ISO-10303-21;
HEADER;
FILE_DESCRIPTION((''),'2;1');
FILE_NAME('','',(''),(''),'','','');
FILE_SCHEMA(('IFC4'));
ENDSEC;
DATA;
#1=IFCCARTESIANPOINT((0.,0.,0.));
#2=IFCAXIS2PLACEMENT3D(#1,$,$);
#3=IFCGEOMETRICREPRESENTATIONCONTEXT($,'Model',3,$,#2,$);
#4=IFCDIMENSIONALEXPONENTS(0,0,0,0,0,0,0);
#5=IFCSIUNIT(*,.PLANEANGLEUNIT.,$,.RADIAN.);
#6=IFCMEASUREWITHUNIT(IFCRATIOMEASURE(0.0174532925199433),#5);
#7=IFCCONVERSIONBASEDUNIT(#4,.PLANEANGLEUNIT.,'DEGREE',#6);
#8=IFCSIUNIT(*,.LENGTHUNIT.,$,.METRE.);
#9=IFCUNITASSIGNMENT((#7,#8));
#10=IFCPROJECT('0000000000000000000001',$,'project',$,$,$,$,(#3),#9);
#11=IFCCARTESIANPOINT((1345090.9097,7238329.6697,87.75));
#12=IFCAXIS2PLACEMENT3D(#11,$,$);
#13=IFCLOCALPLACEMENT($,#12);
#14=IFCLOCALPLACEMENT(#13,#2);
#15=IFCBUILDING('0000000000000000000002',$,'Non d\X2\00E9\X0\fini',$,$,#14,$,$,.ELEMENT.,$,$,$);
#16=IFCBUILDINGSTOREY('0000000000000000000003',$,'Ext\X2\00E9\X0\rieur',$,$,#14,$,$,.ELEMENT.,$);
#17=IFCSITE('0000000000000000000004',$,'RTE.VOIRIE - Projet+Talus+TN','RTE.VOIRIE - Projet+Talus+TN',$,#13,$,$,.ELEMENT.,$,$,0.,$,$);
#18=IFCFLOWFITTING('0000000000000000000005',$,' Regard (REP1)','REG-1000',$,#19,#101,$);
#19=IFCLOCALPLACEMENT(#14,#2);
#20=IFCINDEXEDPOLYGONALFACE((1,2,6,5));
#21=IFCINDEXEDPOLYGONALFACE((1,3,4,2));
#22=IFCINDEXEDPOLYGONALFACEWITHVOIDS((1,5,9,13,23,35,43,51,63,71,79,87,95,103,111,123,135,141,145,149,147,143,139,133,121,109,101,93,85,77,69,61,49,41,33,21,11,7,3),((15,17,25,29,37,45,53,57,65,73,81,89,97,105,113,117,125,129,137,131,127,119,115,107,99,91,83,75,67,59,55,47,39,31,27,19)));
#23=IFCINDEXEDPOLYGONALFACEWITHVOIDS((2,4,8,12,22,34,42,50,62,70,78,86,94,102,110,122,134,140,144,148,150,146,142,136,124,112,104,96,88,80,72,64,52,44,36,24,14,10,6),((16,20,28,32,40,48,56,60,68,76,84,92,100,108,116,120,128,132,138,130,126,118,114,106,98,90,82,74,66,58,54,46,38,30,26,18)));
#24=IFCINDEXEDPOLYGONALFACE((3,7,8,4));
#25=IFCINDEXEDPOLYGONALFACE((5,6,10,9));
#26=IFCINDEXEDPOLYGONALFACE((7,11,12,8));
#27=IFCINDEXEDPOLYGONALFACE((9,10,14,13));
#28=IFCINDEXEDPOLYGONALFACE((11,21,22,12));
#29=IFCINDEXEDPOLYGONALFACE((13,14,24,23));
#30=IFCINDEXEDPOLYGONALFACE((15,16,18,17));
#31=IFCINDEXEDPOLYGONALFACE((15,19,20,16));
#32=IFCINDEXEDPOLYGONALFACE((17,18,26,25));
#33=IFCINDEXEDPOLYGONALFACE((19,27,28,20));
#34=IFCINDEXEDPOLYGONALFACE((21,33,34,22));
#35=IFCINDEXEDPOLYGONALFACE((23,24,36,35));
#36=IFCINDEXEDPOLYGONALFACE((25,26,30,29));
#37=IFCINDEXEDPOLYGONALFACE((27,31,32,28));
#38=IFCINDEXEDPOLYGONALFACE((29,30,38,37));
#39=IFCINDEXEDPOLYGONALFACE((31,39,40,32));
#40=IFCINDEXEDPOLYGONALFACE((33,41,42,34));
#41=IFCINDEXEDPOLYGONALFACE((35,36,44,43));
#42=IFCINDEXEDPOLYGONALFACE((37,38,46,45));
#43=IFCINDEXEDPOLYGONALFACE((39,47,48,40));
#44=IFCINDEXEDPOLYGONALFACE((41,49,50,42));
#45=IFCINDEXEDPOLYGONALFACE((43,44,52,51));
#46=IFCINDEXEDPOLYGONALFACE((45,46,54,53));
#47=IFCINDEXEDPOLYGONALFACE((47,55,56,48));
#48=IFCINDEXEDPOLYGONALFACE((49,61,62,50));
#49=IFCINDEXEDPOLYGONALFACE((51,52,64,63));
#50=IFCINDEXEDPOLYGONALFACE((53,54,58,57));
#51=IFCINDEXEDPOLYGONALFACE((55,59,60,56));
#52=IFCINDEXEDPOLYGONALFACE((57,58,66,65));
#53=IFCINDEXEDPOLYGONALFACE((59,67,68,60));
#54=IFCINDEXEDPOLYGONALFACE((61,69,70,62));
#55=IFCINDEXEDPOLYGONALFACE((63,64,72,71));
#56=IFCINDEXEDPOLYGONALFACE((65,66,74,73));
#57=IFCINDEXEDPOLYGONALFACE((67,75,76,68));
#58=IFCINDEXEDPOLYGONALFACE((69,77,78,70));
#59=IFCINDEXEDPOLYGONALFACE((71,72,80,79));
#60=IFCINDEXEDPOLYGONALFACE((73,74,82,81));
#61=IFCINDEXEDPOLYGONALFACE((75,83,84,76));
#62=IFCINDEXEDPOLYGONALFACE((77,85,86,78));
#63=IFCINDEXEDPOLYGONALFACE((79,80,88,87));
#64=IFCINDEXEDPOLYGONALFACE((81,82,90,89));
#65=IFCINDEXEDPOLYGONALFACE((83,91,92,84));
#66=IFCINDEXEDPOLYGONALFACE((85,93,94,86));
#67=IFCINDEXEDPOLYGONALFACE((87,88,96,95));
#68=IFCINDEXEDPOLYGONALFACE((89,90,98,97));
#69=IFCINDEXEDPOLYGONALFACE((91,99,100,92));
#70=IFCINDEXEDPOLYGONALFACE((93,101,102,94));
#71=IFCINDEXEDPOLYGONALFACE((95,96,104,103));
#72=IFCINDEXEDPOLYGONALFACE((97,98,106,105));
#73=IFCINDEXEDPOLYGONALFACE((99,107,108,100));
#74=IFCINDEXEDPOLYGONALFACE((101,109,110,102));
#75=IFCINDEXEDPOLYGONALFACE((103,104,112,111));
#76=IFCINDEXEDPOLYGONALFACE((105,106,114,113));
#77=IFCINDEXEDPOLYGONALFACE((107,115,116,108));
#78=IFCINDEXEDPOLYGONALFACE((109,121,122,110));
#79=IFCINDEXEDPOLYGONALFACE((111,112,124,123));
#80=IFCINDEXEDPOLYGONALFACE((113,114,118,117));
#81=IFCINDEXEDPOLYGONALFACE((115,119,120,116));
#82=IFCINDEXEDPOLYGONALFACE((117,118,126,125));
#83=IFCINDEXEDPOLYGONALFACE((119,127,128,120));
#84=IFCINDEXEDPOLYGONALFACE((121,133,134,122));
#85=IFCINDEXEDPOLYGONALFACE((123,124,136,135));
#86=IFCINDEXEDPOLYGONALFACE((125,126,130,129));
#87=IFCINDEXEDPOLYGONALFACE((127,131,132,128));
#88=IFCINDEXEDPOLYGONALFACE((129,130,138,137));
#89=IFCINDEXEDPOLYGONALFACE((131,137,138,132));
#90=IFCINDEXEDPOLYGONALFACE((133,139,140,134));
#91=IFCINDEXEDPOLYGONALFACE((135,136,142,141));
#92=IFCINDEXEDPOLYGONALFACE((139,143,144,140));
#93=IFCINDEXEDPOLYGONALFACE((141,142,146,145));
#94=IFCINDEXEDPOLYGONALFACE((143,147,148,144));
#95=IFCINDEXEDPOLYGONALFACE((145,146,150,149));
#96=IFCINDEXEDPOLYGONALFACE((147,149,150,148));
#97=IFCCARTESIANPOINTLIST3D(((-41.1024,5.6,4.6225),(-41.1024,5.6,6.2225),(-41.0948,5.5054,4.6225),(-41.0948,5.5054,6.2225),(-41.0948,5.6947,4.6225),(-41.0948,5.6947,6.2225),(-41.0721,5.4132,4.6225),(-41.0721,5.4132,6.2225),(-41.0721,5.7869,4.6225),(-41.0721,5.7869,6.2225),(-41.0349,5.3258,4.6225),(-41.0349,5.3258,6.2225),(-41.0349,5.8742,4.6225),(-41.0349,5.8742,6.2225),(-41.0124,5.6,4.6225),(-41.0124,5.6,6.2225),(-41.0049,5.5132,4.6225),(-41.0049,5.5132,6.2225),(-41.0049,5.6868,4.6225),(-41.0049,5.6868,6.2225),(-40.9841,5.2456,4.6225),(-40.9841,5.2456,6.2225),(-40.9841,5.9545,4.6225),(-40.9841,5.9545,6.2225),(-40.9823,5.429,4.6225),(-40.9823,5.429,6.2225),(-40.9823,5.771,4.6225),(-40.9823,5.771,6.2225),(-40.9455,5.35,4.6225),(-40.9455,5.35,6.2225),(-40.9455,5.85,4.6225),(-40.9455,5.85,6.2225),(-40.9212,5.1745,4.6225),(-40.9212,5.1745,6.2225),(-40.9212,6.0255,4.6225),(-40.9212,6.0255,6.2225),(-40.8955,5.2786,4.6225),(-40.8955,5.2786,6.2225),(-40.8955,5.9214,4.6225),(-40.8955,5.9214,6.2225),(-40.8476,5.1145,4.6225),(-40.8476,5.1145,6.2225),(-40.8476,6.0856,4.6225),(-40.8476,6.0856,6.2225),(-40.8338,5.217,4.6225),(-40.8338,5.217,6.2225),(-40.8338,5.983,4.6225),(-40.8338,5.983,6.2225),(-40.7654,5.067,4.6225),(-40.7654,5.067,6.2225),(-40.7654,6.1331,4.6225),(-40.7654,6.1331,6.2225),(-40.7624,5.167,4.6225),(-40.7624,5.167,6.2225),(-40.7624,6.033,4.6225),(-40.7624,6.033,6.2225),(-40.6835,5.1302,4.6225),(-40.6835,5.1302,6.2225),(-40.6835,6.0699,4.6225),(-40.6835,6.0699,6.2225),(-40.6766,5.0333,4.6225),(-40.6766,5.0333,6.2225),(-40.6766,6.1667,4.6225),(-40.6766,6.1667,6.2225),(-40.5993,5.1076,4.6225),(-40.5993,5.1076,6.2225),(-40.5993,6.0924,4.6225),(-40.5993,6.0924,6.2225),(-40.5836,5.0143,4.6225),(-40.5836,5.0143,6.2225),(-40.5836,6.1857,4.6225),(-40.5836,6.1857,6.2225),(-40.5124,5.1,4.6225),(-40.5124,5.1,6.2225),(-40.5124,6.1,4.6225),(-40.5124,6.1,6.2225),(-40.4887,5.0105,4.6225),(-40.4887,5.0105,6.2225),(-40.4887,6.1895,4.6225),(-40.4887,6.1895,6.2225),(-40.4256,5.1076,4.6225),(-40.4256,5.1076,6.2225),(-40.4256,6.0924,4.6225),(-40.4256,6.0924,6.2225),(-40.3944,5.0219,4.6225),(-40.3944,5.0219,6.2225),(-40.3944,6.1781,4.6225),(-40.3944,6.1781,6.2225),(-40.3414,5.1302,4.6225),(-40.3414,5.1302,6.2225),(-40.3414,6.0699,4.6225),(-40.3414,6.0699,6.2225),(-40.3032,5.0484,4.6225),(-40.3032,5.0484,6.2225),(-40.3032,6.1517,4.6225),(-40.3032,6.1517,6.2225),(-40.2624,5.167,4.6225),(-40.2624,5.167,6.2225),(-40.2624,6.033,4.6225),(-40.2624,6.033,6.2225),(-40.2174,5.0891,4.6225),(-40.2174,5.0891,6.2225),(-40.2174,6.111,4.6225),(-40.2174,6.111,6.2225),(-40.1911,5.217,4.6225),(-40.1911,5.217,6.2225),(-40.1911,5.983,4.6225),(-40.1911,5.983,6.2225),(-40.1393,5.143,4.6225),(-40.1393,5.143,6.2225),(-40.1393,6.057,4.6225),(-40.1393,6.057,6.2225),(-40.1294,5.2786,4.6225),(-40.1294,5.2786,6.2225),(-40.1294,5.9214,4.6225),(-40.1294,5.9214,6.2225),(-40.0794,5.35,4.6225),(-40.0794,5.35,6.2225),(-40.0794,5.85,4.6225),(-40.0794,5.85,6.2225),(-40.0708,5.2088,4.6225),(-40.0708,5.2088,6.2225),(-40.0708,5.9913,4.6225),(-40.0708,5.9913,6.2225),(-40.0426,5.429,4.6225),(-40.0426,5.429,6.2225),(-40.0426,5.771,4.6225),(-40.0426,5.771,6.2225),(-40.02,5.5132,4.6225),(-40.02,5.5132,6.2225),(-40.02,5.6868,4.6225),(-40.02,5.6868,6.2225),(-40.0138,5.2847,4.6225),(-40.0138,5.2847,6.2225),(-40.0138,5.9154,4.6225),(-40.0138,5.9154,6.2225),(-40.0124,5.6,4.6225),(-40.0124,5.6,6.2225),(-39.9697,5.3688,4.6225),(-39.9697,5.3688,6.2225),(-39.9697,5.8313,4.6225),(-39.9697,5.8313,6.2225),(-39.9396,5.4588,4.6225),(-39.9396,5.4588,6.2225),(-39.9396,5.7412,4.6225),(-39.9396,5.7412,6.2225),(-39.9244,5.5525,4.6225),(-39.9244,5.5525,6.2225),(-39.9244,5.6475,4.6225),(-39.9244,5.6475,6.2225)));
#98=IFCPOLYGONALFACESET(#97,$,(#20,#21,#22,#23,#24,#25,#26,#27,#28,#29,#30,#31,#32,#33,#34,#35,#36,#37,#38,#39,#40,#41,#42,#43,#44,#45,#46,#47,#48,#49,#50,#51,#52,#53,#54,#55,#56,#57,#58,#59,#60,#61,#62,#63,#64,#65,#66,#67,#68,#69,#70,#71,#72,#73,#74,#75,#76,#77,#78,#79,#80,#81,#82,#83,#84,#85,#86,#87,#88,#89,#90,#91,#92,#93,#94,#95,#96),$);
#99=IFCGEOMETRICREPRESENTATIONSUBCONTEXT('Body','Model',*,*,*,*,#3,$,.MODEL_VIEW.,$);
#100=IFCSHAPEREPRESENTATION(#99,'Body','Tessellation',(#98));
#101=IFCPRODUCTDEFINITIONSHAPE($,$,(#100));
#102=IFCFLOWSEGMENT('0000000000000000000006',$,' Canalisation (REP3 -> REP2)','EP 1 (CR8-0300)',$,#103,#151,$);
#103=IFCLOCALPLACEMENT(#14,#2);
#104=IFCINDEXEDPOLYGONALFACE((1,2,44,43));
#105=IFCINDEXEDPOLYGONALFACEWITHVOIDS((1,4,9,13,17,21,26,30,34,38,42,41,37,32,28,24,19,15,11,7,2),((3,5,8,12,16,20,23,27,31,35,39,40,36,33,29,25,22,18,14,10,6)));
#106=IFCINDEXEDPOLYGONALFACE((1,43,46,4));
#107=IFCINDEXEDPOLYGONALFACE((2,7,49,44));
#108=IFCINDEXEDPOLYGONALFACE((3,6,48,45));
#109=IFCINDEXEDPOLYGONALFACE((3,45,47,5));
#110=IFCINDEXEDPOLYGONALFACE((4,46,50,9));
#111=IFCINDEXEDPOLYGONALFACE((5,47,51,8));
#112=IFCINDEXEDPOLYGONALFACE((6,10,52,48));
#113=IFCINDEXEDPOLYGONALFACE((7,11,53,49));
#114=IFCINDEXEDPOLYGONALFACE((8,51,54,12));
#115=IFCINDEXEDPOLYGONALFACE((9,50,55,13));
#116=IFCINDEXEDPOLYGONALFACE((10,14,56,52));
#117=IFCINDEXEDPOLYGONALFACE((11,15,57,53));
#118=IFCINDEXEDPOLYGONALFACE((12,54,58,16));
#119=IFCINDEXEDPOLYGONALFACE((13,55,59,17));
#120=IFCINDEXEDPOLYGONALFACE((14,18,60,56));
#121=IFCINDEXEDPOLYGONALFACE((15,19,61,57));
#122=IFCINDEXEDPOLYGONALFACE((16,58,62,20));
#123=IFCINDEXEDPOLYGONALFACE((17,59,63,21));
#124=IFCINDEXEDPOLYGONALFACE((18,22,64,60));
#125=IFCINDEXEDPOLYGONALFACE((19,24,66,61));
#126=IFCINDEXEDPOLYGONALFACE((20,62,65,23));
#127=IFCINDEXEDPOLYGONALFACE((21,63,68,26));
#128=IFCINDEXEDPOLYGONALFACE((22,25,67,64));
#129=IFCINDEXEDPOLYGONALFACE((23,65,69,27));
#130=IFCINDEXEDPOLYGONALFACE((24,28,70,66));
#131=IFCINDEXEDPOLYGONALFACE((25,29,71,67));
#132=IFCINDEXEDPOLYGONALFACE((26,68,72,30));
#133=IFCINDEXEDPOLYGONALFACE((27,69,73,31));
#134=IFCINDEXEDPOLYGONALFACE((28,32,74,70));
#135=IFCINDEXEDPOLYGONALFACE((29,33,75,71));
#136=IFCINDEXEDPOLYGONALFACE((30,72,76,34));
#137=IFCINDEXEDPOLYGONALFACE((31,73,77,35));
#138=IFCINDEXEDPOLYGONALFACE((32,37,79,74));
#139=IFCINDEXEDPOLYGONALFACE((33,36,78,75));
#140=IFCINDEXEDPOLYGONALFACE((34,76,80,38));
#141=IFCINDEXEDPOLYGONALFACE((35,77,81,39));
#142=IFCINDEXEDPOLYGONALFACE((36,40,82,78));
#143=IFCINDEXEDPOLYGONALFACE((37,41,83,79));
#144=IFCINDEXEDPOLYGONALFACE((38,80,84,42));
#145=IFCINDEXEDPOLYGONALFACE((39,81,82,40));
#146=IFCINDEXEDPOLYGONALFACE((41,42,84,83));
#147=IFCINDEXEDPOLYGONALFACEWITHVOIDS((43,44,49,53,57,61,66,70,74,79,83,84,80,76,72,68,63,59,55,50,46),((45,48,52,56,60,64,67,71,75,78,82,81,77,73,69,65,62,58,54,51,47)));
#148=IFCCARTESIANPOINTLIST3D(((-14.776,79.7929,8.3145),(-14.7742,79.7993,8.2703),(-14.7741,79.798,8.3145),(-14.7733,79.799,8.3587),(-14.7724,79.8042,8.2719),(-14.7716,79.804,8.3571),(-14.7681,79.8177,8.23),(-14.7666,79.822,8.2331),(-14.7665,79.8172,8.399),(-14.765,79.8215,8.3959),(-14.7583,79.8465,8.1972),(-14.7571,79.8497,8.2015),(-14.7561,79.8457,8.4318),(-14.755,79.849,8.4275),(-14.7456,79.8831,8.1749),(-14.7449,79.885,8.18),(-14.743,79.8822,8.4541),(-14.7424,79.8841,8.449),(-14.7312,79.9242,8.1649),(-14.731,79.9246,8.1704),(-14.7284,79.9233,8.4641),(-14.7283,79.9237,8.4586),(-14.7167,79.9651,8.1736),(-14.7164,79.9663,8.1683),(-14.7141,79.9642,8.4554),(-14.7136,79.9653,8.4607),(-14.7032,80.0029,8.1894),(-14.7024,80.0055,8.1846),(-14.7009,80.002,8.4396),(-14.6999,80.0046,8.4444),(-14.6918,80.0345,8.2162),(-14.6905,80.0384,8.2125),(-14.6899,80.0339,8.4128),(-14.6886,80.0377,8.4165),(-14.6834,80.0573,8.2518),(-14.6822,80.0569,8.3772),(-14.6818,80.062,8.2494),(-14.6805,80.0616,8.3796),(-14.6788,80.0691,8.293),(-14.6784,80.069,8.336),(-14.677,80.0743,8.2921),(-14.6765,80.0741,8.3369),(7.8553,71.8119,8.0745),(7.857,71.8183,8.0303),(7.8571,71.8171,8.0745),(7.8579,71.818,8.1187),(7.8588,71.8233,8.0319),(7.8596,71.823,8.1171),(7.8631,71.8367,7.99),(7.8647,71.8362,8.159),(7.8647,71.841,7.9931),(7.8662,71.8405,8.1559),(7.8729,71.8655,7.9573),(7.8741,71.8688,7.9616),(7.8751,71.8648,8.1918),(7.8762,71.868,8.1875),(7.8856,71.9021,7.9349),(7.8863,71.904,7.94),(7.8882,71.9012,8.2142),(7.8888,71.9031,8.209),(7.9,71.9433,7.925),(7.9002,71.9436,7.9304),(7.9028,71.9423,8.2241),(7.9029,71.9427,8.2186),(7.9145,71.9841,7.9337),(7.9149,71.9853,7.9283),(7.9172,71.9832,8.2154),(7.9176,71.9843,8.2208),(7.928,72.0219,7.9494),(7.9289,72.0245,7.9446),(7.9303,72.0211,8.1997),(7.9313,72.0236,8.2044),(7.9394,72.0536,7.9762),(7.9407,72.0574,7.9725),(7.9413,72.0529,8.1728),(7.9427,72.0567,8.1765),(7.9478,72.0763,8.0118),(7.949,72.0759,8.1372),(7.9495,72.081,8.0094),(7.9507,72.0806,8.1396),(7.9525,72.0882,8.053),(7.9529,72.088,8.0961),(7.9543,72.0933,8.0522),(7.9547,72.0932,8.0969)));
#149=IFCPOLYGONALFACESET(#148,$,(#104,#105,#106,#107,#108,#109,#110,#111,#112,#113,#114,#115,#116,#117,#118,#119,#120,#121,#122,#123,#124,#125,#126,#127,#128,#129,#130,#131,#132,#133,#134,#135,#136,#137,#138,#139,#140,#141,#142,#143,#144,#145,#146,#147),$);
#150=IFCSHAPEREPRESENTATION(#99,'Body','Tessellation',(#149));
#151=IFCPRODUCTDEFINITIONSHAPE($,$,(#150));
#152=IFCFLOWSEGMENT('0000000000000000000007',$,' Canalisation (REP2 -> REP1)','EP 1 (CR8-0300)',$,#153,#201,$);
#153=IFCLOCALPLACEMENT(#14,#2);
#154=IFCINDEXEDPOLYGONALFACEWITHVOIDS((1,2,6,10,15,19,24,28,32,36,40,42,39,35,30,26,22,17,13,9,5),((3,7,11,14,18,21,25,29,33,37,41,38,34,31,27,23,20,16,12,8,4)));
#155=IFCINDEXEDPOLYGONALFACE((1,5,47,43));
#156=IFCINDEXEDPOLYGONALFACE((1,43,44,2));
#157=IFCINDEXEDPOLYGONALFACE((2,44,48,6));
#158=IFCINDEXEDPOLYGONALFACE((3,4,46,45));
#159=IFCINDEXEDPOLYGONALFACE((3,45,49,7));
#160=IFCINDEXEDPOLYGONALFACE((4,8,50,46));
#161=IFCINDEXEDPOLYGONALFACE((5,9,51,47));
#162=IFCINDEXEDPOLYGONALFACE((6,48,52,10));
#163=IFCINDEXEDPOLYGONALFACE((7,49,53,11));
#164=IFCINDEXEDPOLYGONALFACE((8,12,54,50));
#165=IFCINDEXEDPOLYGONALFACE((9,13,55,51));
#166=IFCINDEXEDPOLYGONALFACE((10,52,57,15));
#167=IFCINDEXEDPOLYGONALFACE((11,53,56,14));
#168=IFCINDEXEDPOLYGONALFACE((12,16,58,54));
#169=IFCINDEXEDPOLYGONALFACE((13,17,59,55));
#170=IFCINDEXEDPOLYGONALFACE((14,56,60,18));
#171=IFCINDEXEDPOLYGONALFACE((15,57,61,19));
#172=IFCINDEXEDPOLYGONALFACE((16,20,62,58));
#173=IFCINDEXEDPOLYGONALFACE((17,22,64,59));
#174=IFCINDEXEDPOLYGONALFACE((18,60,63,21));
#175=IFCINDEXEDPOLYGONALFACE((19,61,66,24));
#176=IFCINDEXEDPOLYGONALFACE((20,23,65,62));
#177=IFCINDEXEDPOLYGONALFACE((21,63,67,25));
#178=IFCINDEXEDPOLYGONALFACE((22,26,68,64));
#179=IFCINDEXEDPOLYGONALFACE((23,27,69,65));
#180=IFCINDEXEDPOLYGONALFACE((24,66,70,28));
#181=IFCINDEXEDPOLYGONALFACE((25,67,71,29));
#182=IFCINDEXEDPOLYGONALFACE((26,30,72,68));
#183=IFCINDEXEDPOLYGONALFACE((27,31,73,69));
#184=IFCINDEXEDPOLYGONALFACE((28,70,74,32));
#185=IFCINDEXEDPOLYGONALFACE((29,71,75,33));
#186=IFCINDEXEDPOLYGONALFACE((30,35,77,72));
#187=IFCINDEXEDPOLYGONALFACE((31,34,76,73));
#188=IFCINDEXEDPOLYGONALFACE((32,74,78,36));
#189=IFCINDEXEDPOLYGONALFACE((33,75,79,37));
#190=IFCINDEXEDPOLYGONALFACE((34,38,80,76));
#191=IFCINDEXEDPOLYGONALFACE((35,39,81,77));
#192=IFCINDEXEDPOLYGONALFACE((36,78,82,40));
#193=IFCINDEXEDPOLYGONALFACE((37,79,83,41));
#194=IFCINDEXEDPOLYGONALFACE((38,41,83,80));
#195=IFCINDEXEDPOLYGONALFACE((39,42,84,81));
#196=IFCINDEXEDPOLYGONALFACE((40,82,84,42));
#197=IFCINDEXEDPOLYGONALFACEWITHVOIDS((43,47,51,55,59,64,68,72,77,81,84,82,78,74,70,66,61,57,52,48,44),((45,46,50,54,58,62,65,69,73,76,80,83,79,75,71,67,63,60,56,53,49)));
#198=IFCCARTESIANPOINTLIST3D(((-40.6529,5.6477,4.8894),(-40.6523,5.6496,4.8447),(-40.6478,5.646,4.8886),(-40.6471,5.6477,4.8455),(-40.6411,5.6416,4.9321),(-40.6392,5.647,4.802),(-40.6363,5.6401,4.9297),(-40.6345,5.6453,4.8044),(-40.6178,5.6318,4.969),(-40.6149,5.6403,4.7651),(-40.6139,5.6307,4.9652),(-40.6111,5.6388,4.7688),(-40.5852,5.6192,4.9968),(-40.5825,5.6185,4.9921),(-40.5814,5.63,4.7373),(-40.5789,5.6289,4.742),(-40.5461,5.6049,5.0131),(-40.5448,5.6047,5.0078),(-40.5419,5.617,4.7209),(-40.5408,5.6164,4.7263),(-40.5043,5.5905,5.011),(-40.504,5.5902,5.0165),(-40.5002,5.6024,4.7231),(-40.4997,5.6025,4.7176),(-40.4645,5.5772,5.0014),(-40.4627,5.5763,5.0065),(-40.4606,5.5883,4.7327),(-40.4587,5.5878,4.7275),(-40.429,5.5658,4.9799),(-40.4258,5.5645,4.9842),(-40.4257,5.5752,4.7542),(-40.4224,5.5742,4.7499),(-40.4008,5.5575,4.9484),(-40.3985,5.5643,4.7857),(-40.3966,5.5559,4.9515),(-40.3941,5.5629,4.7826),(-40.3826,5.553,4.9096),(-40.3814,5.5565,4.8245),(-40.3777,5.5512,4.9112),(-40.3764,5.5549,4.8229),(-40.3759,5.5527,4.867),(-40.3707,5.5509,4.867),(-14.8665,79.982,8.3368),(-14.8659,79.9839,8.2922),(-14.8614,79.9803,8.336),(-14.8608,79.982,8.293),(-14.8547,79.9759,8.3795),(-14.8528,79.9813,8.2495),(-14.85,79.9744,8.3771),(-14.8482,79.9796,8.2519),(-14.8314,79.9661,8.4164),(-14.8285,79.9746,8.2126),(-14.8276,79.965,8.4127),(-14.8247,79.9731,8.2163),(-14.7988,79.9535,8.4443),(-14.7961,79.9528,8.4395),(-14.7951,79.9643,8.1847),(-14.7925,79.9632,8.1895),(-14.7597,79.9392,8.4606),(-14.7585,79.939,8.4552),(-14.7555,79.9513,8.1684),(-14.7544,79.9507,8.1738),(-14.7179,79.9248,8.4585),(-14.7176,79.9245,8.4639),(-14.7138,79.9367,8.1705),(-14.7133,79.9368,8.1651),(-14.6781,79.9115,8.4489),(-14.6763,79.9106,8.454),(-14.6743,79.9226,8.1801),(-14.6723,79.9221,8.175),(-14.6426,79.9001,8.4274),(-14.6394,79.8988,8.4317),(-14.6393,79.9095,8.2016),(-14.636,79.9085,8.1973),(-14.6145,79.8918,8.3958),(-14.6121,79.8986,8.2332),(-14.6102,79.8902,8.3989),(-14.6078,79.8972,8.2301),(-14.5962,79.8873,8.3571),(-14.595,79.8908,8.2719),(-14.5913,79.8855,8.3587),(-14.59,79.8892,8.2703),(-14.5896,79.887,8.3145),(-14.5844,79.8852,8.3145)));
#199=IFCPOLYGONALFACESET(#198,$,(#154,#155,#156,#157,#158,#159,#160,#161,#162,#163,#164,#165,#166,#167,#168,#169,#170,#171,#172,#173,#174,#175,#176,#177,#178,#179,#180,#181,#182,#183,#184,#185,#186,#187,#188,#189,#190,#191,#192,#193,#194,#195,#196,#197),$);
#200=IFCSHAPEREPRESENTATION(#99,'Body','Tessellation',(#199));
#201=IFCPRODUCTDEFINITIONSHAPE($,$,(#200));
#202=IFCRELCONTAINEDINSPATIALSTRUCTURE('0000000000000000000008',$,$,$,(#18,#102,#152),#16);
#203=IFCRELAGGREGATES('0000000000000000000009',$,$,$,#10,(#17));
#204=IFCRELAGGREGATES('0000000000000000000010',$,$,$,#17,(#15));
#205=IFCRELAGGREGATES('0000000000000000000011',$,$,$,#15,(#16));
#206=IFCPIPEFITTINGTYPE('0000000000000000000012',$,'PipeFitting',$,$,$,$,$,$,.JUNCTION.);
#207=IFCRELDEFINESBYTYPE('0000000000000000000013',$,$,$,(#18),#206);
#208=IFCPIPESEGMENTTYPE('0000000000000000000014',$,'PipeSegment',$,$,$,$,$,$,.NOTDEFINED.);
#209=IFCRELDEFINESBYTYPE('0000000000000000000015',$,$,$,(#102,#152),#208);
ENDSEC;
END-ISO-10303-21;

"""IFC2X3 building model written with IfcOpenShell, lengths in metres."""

from ifc_helpers import new_model, entity, si_unit, converted_unit, frame, origin, origin_2d_with_axis, place, context, subcontext, project, spatial, hollow_circle, extrude, type_object, element, save


model = new_model("IFC2X3")

# Units and contexts
model_context = context("Model", 3, world=origin())
body_context = subcontext(model_context, "Body", "Model", "MODEL_VIEW")
ifc_project = project(units=[converted_unit("PLANEANGLEUNIT", "DEGREE", entity("IfcRatioMeasure", 0.0174532925199433), si_unit("PLANEANGLEUNIT", "RADIAN"), dimensions=[0, 0, 0, 0, 0, 0, 0]), si_unit("LENGTHUNIT", "METRE")], contexts=[model_context])

# Site, building, storey
site_placement = place(None, frame((1345090.9097, 7238329.6697, 87.75)))
site = spatial("IfcSite", under=ifc_project, at=site_placement, Name="RTE.VOIRIE - Projet+Talus+TN", Description="RTE.VOIRIE - Projet+Talus+TN", CompositionType="ELEMENT", RefElevation=0.0)
placement = place(site_placement, origin())
building = spatial("IfcBuilding", under=site, at=placement, Name="Non défini", CompositionType="ELEMENT")
storey = spatial("IfcBuildingStorey", under=building, at=placement, Name="Extérieur", CompositionType="ELEMENT")

# Flow fitting
pipe_fitting_type_1 = type_object("IfcPipeFittingType", Name="PipeFitting", PredefinedType="JUNCTION")
flow_fitting_1_placement = place(placement, origin())
element("IfcFlowFitting", 1, at=flow_fitting_1_placement, inside=storey, type_object=pipe_fitting_type_1, Name=" Regard (REP1)", Description="REG-1000", context=body_context, shape_type="SweptSolid", body=[
    extrude(hollow_circle(Radius=0.59, WallThickness=0.09, at=origin_2d_with_axis()), frame((-40.5124, 5.6, 4.6225), z_axis=(0.0, 0.0, 1.0), x_axis=(-1.0, 0.0, 0.0)), (0.0, 0.0, 1.0), 1.6),
])

# Flow segments
pipe_segment_type_1 = type_object("IfcPipeSegmentType", Name="PipeSegment", PredefinedType="NOTDEFINED")
flow_segment_1_placement = place(placement, origin())
element("IfcFlowSegment", 2, at=flow_segment_1_placement, inside=storey, type_object=pipe_segment_type_1, Name=" Canalisation (REP3 -> REP2)", Description="EP 1 (CR8-0300)", context=body_context, shape_type="SweptSolid", body=[
    extrude(hollow_circle(Radius=0.15, WallThickness=0.0055, at=origin_2d_with_axis()), frame((7.9051, 71.9533, 8.0745), z_axis=(-0.943028, 0.332562, 0.01), x_axis=(-0.332562, -0.943028, 0.0)), (0.0, 0.0, 1.0), 23.9985),
])
flow_segment_2_placement = place(placement, origin())
element("IfcFlowSegment", 3, at=flow_segment_2_placement, inside=storey, type_object=pipe_segment_type_1, Name=" Canalisation (REP2 -> REP1)", Description="EP 1 (CR8-0300)", context=body_context, shape_type="SweptSolid", body=[
    extrude(hollow_circle(Radius=0.15, WallThickness=0.0055, at=origin_2d_with_axis()), frame((-14.7261, 79.9343, 8.3145), z_axis=(-0.327424, -0.943863, -0.043774), x_axis=(0.943863, -0.327424, 0.0)), (0.0, 0.0, 1.0), 78.7554),
])

save(model, "model.ifc")
